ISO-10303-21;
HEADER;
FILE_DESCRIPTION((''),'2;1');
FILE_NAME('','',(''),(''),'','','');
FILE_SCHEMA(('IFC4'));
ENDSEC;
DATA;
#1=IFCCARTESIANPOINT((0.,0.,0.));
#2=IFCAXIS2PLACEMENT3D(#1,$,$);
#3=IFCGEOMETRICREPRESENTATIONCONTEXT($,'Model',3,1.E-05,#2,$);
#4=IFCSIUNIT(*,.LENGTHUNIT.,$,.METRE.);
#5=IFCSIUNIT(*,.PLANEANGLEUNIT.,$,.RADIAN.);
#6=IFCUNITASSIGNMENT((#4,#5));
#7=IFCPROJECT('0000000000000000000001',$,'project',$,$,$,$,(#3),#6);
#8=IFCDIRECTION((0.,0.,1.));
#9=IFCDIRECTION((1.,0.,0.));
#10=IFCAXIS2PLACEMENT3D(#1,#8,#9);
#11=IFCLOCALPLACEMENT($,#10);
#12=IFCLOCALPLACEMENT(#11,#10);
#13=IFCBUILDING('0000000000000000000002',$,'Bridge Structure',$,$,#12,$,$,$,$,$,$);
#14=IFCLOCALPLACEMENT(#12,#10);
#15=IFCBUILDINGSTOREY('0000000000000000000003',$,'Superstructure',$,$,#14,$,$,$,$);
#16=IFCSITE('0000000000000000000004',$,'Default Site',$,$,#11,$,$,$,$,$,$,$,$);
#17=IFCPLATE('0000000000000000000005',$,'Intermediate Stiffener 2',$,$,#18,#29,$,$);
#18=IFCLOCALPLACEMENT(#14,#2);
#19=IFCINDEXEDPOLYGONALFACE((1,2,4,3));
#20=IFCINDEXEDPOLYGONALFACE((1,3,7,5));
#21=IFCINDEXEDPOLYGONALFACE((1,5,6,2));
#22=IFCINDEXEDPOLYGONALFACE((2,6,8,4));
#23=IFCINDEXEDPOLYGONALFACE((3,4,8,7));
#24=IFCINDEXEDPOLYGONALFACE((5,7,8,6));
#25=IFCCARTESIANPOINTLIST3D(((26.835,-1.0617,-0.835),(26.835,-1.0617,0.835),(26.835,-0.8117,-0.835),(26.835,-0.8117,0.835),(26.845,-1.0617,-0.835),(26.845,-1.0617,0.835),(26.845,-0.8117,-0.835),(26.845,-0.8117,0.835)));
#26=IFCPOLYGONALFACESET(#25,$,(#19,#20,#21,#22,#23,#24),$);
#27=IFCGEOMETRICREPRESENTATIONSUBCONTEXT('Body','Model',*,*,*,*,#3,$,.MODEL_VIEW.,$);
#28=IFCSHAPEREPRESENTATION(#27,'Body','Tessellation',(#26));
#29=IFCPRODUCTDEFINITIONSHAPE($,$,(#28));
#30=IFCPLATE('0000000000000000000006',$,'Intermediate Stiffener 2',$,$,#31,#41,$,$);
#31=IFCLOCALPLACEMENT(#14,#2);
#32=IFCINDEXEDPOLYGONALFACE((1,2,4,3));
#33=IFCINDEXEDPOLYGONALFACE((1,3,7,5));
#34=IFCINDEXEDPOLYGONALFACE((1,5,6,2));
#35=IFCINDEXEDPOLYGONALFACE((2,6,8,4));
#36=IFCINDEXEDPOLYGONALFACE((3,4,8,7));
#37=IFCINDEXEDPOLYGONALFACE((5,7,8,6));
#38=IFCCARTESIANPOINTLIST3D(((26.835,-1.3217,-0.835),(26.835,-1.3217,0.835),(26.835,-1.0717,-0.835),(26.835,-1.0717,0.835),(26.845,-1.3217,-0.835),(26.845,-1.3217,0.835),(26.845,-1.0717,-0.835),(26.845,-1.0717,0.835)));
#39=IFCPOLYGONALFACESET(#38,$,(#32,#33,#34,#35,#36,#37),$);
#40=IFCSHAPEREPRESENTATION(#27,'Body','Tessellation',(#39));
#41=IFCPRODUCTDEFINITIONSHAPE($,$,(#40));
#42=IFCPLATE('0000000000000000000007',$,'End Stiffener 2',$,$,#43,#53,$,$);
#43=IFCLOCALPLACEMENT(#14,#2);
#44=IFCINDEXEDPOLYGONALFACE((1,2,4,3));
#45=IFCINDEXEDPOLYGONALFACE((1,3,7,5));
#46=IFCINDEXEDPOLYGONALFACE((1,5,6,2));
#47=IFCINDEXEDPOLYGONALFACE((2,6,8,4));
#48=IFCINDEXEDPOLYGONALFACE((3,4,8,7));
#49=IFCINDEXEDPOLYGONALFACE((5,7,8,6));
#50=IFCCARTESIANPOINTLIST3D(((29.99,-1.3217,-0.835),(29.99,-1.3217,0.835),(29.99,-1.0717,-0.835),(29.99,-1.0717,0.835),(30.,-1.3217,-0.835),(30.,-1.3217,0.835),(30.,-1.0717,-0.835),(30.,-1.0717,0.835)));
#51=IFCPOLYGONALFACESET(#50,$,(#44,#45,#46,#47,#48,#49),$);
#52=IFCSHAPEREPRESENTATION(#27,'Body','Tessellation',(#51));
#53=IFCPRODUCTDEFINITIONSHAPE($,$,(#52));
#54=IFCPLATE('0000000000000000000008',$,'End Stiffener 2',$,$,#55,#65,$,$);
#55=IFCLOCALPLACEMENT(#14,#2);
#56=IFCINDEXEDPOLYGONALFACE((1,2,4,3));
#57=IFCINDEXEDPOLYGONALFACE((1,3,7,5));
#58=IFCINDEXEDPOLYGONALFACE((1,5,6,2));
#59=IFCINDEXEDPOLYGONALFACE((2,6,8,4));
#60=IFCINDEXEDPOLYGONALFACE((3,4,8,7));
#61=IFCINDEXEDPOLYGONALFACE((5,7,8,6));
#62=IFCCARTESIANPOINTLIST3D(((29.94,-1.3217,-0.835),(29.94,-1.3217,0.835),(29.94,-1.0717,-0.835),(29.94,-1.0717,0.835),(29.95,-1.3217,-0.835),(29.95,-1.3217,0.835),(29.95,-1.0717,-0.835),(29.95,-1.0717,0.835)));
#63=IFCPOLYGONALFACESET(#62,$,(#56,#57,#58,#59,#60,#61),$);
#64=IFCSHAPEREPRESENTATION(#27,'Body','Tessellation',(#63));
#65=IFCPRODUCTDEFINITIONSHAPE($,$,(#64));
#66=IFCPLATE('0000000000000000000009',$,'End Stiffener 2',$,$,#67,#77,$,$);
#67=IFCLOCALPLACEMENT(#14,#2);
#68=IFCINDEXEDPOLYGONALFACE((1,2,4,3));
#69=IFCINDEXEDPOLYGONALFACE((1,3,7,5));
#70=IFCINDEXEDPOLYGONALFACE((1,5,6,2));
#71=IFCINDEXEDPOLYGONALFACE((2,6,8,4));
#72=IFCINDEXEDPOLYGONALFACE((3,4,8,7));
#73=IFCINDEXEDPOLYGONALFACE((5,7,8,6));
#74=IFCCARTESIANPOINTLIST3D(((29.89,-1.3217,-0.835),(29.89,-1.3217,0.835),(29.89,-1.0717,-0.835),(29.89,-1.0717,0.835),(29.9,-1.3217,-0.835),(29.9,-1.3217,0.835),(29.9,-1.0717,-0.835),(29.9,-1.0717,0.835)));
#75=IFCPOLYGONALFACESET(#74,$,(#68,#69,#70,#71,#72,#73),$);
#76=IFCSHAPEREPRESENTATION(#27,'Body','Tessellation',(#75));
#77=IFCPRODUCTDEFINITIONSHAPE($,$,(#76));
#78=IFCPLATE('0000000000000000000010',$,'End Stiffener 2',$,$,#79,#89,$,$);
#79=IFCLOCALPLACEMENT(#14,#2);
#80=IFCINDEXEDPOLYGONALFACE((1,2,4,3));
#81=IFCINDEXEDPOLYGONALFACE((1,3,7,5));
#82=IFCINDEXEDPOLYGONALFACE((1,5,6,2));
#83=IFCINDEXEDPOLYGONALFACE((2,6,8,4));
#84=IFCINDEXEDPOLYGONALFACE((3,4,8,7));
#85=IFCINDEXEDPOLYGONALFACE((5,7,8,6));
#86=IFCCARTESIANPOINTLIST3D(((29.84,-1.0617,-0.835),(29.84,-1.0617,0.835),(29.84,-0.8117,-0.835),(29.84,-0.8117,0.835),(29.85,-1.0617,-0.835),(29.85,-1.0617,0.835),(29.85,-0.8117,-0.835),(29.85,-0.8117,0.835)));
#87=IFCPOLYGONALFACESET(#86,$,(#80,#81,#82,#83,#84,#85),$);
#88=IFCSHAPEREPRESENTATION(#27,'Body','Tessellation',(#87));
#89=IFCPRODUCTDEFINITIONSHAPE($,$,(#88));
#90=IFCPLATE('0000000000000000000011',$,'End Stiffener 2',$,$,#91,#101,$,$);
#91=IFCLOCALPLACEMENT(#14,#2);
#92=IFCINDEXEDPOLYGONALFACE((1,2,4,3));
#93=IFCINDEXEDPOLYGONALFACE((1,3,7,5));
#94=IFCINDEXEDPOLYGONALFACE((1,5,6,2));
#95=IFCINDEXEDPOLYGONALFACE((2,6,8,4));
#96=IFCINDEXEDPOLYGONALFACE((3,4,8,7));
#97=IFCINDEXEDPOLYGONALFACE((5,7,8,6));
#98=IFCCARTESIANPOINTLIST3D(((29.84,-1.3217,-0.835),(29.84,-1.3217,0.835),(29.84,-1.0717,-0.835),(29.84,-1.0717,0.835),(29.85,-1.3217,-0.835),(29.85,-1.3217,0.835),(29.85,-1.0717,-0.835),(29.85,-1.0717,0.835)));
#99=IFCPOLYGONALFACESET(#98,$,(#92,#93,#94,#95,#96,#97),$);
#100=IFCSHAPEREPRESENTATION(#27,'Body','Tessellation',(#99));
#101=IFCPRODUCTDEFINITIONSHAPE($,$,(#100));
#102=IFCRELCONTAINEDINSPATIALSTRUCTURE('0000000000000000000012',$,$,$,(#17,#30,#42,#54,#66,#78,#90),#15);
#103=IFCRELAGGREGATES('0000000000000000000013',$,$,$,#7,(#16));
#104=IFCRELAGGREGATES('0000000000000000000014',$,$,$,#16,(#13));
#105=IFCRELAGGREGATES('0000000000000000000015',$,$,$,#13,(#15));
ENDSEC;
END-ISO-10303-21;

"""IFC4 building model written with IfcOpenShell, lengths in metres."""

from ifc_helpers import new_model, si_unit, frame, origin, origin_with_axes, origin_2d_with_axis, place, context, subcontext, project, spatial, rectangle, extrude, element, save


model = new_model("IFC4")

# Units and contexts
model_context = context("Model", 3, precision=1e-05, world=origin())
body_context = subcontext(model_context, "Body", "Model", "MODEL_VIEW")
ifc_project = project(units=[si_unit("LENGTHUNIT", "METRE"), si_unit("PLANEANGLEUNIT", "RADIAN")], contexts=[model_context])

# Site, building, storey
site_placement = place(None, origin_with_axes())
site = spatial("IfcSite", under=ifc_project, at=site_placement, Name="Default Site")
building_placement = place(site_placement, origin_with_axes())
building = spatial("IfcBuilding", under=site, at=building_placement, Name="Bridge Structure")
storey_placement = place(building_placement, origin_with_axes())
storey = spatial("IfcBuildingStorey", under=building, at=storey_placement, Name="Superstructure")

# Plates
for number, where, z_axis, x_axis, name in (
    (1, (26.84, -0.9367, -0.835), (0.0, 0.0, 1.0), (1.0, 0.0, 0.0), "Intermediate Stiffener 2"),
    (2, (26.84, -1.1967, -0.835), (0.0, 0.0, 1.0), (1.0, 0.0, 0.0), "Intermediate Stiffener 2"),
    (3, (29.995, -1.1967, -0.835), (0.0, 0.0, 1.0), (1.0, 0.0, 0.0), "End Stiffener 2"),
    (4, (29.945, -1.1967, -0.835), (0.0, 0.0, 1.0), (1.0, 0.0, 0.0), "End Stiffener 2"),
    (5, (29.895, -1.1967, -0.835), (0.0, 0.0, 1.0), (1.0, 0.0, 0.0), "End Stiffener 2"),
    (6, (29.845, -0.9367, -0.835), (0.0, 0.0, 1.0), (1.0, 0.0, 0.0), "End Stiffener 2"),
    (7, (29.845, -1.1967, -0.835), (0.0, 0.0, 1.0), (1.0, 0.0, 0.0), "End Stiffener 2"),
):
    element("IfcPlate", number, at=place(storey_placement, frame(where, z_axis=z_axis, x_axis=x_axis)), inside=storey, Name=name, context=body_context, shape_type="SweptSolid", body=[
        extrude(rectangle(XDim=0.01, YDim=0.25, at=origin_2d_with_axis()), origin_with_axes(), (0.0, 0.0, 1.0), 1.67),
    ])

save(model, "model.ifc")
